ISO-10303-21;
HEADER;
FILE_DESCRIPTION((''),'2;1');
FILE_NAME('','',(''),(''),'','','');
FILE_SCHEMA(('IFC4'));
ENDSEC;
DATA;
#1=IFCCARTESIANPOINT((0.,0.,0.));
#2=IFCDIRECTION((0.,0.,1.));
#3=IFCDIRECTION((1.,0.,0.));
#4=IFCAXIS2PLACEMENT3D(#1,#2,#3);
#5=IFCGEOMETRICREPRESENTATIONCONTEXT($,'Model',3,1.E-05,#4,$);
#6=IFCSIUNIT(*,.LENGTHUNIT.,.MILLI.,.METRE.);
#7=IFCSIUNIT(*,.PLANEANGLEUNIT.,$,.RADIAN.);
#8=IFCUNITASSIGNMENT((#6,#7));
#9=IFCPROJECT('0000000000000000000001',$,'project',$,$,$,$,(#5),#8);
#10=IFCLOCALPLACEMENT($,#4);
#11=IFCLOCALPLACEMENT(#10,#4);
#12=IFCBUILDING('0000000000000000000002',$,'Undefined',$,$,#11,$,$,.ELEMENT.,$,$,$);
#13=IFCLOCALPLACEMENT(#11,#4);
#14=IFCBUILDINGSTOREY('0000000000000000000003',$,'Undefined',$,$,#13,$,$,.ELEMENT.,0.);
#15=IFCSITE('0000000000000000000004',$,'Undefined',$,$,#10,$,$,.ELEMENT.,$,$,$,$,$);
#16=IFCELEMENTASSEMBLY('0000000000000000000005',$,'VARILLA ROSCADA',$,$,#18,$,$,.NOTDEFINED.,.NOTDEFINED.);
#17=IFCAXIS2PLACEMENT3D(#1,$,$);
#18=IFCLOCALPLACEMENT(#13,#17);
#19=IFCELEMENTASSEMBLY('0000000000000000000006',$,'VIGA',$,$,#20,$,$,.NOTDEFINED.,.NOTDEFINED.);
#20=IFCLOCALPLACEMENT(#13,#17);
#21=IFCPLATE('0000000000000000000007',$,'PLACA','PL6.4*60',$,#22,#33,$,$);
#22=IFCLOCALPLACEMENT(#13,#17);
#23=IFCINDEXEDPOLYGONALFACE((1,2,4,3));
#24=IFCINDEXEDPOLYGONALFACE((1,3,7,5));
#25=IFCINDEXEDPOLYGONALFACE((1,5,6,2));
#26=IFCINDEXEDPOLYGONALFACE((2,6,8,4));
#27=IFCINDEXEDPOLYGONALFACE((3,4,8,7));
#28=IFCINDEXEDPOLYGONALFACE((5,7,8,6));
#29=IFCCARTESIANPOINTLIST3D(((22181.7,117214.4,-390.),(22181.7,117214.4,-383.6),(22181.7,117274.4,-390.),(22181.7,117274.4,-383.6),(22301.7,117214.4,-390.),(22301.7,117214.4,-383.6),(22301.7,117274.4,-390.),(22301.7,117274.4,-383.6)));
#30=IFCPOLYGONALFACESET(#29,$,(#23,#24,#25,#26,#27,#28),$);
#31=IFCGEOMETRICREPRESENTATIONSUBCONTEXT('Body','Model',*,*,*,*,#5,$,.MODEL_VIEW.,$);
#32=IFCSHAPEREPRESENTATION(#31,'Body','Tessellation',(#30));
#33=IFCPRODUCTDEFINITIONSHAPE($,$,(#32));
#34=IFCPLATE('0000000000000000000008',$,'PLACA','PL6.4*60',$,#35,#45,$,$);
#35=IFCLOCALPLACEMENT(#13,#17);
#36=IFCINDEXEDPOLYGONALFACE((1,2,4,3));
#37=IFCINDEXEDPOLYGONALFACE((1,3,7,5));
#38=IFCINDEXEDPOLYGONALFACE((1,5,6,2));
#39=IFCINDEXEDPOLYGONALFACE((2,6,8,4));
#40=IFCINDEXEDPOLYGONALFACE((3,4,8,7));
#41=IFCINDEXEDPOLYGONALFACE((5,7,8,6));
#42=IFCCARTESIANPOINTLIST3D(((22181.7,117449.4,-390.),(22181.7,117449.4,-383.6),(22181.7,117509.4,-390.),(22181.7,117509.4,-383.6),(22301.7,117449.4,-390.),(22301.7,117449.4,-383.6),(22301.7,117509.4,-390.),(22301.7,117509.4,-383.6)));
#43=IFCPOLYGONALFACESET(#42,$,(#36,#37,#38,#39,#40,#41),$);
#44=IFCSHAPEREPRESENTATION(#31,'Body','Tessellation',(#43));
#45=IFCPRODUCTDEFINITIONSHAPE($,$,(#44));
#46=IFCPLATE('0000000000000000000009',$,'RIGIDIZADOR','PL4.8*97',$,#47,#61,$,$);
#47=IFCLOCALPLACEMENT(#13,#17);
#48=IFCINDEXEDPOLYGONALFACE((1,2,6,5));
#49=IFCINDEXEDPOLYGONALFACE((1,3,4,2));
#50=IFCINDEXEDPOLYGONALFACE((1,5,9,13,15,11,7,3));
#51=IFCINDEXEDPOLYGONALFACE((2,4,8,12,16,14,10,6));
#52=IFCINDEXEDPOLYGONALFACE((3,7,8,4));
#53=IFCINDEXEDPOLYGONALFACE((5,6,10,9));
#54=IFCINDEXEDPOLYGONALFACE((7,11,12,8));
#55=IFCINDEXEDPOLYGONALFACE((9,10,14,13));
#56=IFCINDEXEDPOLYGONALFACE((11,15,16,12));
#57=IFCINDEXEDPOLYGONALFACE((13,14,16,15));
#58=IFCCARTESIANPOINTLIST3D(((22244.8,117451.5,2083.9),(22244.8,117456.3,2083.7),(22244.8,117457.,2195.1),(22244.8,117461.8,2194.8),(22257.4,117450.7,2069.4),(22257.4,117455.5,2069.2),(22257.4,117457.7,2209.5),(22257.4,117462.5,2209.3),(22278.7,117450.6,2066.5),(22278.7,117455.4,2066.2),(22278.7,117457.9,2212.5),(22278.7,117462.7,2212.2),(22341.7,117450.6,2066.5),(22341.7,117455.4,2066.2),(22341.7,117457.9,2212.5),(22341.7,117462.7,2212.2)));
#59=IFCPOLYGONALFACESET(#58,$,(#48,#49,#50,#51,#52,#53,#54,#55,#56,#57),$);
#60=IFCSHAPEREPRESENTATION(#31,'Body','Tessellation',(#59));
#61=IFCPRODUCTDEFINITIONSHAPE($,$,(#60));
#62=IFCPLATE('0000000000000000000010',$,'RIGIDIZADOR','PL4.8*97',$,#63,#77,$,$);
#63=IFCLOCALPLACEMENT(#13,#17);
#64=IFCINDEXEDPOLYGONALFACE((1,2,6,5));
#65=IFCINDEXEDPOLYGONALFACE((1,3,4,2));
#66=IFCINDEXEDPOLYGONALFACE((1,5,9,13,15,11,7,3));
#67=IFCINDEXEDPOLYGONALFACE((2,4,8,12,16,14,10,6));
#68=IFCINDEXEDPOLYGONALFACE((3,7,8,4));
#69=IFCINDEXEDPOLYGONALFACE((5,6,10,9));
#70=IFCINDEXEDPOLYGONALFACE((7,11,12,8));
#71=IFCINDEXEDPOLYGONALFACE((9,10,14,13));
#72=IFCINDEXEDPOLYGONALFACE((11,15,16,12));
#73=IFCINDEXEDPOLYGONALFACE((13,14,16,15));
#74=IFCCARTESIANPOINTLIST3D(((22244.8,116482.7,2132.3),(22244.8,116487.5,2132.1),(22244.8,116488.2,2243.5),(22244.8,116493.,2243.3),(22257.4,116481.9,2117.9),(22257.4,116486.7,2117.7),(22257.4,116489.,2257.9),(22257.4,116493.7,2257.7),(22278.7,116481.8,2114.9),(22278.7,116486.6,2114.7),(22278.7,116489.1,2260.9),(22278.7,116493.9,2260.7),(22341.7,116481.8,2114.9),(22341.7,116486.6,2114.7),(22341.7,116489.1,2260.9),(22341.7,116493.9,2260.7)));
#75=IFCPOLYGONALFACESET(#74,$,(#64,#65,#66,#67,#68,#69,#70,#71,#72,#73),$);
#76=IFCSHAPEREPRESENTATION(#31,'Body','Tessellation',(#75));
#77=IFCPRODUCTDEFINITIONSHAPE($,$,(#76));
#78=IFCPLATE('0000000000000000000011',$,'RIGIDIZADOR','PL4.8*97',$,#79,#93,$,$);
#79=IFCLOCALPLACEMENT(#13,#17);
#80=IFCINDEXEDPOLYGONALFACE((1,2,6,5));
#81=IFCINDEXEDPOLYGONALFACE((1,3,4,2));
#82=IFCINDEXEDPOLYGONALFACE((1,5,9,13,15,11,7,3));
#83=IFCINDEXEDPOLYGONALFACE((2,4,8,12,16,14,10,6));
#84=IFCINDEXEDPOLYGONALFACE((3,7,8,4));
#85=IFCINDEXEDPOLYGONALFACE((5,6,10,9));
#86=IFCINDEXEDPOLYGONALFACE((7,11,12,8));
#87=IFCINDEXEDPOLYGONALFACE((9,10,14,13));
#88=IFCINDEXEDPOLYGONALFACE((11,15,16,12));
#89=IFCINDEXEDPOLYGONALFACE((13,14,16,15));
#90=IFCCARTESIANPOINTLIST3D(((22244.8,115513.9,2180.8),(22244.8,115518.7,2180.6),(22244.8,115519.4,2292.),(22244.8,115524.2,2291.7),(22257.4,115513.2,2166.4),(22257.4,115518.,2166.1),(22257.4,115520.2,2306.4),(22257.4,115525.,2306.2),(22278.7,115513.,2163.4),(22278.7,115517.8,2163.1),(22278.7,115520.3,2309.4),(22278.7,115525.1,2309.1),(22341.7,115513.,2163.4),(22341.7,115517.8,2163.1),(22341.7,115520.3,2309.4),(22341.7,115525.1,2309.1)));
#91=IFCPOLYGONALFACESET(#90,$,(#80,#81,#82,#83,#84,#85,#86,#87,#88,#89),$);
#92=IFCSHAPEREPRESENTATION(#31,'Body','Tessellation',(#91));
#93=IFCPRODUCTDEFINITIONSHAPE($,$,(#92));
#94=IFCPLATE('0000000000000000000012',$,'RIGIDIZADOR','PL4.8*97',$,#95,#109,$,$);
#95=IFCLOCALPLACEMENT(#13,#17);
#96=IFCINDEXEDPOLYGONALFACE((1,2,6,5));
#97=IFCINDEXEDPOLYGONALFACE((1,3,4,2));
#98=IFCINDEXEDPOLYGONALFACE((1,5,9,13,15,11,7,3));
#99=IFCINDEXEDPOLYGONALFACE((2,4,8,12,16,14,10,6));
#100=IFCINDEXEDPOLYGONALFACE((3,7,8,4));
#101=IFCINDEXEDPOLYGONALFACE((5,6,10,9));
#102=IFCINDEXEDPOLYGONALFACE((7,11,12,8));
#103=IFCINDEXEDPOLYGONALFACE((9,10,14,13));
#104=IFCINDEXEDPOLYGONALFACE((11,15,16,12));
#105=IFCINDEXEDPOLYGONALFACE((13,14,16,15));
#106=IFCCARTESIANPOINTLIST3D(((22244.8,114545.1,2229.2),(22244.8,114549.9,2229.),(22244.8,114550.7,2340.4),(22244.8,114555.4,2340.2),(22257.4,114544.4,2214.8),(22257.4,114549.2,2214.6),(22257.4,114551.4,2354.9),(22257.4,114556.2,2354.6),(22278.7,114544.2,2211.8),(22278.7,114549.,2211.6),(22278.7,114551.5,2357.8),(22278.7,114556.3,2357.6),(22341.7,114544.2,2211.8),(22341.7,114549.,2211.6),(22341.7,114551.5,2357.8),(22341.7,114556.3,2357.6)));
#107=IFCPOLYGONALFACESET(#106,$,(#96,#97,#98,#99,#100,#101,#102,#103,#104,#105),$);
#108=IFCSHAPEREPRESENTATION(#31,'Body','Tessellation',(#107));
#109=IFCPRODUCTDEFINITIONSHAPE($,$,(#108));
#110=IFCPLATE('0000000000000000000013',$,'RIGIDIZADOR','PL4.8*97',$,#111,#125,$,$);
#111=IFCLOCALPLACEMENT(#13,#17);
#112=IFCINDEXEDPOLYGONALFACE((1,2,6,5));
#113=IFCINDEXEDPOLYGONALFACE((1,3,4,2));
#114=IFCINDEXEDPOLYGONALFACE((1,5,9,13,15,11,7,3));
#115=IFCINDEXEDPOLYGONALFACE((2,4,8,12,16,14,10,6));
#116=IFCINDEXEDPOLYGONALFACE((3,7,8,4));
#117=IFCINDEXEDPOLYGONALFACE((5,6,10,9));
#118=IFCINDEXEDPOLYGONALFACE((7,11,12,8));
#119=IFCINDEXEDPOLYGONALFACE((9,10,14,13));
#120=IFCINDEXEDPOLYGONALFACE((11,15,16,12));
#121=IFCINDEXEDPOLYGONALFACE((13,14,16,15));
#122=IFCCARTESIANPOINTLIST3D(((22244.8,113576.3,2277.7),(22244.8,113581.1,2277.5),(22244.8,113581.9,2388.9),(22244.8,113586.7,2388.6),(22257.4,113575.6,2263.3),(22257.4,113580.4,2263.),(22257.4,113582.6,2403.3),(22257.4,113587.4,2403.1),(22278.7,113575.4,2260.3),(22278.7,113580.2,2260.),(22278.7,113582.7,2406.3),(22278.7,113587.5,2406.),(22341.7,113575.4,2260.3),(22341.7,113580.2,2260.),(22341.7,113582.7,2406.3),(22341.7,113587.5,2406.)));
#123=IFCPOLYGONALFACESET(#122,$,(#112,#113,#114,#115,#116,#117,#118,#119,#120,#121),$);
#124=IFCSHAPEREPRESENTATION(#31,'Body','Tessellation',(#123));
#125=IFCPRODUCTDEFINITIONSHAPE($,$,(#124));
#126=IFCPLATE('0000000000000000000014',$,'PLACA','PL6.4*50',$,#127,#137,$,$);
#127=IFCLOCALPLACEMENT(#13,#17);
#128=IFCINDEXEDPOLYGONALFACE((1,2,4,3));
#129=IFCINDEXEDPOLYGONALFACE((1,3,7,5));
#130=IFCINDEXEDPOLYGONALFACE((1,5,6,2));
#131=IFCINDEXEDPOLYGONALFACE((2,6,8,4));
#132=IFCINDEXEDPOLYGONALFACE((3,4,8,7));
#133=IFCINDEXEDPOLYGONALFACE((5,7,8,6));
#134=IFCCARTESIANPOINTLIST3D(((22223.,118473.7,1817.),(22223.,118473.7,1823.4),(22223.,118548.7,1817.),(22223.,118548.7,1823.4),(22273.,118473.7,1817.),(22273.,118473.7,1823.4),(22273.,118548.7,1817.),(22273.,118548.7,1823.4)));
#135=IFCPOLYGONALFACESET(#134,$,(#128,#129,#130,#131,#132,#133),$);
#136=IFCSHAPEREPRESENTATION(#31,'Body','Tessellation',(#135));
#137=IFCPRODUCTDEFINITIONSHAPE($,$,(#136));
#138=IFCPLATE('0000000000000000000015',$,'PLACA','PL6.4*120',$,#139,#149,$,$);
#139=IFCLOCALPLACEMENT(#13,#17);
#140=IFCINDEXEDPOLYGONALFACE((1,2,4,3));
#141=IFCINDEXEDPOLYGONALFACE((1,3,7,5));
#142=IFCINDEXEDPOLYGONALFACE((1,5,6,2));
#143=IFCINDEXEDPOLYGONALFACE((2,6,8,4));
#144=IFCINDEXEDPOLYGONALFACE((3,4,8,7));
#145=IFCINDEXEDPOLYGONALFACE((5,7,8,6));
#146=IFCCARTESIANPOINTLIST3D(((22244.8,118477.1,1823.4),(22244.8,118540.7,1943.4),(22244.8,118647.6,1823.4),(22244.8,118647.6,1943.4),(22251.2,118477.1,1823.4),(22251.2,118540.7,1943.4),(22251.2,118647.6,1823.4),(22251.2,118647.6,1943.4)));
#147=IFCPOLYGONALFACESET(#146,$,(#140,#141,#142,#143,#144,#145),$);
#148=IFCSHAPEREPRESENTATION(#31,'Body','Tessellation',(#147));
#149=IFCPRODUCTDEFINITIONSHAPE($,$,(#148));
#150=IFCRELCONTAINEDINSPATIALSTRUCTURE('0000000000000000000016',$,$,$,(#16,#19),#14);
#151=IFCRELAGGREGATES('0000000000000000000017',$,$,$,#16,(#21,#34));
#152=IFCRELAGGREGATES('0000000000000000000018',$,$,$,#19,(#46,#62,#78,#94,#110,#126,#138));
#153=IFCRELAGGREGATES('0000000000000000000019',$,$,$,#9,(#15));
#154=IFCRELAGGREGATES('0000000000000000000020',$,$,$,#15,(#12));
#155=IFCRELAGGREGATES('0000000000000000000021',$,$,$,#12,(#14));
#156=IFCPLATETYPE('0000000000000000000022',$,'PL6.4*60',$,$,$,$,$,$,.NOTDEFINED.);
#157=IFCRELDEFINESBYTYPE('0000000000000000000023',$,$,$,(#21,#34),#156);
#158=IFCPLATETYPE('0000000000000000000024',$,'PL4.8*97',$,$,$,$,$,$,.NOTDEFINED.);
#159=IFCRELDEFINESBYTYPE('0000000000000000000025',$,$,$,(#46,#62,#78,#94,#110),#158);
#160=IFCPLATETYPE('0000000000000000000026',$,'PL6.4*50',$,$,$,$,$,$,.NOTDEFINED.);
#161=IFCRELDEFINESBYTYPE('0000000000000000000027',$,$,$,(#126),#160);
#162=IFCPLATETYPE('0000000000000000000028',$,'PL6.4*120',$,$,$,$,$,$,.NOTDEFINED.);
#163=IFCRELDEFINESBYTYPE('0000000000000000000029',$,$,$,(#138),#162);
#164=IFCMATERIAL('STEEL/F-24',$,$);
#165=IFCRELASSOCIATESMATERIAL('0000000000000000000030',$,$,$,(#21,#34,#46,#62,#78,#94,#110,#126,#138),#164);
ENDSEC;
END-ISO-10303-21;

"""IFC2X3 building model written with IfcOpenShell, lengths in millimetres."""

from ifc_helpers import new_model, si_unit, frame, origin_with_axes, place, context, subcontext, project, spatial, polyline, outline, extrude, material, type_object, element, aggregate, save


model = new_model("IFC2X3")

# Units and contexts
model_context = context("Model", 3, precision=1e-05, world=origin_with_axes())
body_context = subcontext(model_context, "Body", "Model", "MODEL_VIEW")
ifc_project = project(units=[si_unit("LENGTHUNIT", "METRE", prefix="MILLI"), si_unit("PLANEANGLEUNIT", "RADIAN")], contexts=[model_context])

# Site, building, storey
site_placement = place(None, origin_with_axes())
site = spatial("IfcSite", under=ifc_project, at=site_placement, Name="Undefined", CompositionType="ELEMENT")
building_placement = place(site_placement, origin_with_axes())
building = spatial("IfcBuilding", under=site, at=building_placement, Name="Undefined", CompositionType="ELEMENT")
storey_placement = place(building_placement, origin_with_axes())
storey = spatial("IfcBuildingStorey", under=building, at=storey_placement, Name="Undefined", CompositionType="ELEMENT", Elevation=0.0)

# Element assembly
assembly_1_placement = place(storey_placement, origin_with_axes())
assembly_1 = element("IfcElementAssembly", 1, at=assembly_1_placement, inside=storey, Name="VARILLA ROSCADA", AssemblyPlace="NOTDEFINED", PredefinedType="NOTDEFINED")

# Element assembly
assembly_2_placement = place(storey_placement, origin_with_axes())
assembly_2 = element("IfcElementAssembly", 2, at=assembly_2_placement, inside=storey, Name="VIGA", AssemblyPlace="NOTDEFINED", PredefinedType="NOTDEFINED")
ifc_material_1 = material(Name="STEEL/F-24")

# Plates
plate_type_1 = type_object("IfcPlateType", Name="PL6.4*60", PredefinedType="NOTDEFINED")
plate_1_placement = place(assembly_1_placement, frame((22181.7, 117214.4, -386.8), z_axis=(0.0, 0.0, 1.0), x_axis=(1.0, 0.0, 0.0)))
plate_1 = element("IfcPlate", 3, at=plate_1_placement, type_object=plate_type_1, material=ifc_material_1, Name="PLACA", Description="PL6.4*60", context=body_context, shape_type="SweptSolid", body=[
    extrude(outline(polyline([(0.0, 0.0), (120.0, 0.0), (120.0, 60.0), (0.0, 60.0), (0.0, 0.0)])), frame((0.0, 0.0, -3.2), z_axis=(0.0, 0.0, 1.0), x_axis=(1.0, 0.0, 0.0)), (0.0, 0.0, 1.0), 6.4),
])
plate_2_placement = place(assembly_1_placement, frame((22181.7, 117449.4, -386.8), z_axis=(0.0, 0.0, 1.0), x_axis=(1.0, 0.0, 0.0)))
plate_2 = element("IfcPlate", 4, at=plate_2_placement, type_object=plate_type_1, material=ifc_material_1, Name="PLACA", Description="PL6.4*60", context=body_context, shape_type="SweptSolid", body=[
    extrude(outline(polyline([(0.0, 0.0), (120.0, 0.0), (120.0, 60.0), (0.0, 60.0), (0.0, 0.0)])), frame((0.0, 0.0, -3.2), z_axis=(0.0, 0.0, 1.0), x_axis=(1.0, 0.0, 0.0)), (0.0, 0.0, 1.0), 6.4),
])
plate_type_2 = type_object("IfcPlateType", Name="PL4.8*97", PredefinedType="NOTDEFINED")
plate_3_placement = place(assembly_2_placement, frame((22341.7, 117460.3, 2212.4), z_axis=(0.0, -0.998752, 0.04995), x_axis=(-1.0, 0.0, 0.0)))
plate_3 = element("IfcPlate", 5, at=plate_3_placement, type_object=plate_type_2, material=ifc_material_1, Name="RIGIDIZADOR", Description="PL4.8*97", context=body_context, shape_type="SweptSolid", body=[
    extrude(outline(polyline([(0.0, 0.0), (63.0, 0.0), (84.3, 3.0), (96.8, 17.4), (96.8, 128.7), (84.3, 143.2), (63.0, 146.2), (0.0, 146.2), (0.0, 0.0)])), frame((0.0, 0.0, -2.4), z_axis=(0.0, 0.0, 1.0), x_axis=(1.0, 0.0, 0.0)), (0.0, 0.0, 1.0), 4.8),
])
plate_4_placement = place(assembly_2_placement, frame((22341.7, 116491.5, 2260.8), z_axis=(0.0, -0.998752, 0.04995), x_axis=(-1.0, 0.0, 0.0)))
plate_4 = element("IfcPlate", 6, at=plate_4_placement, type_object=plate_type_2, material=ifc_material_1, Name="RIGIDIZADOR", Description="PL4.8*97", context=body_context, shape_type="SweptSolid", body=[
    extrude(outline(polyline([(0.0, 0.0), (63.0, 0.0), (84.3, 3.0), (96.8, 17.4), (96.8, 128.7), (84.3, 143.2), (63.0, 146.2), (0.0, 146.2), (0.0, 0.0)])), frame((0.0, 0.0, -2.4), z_axis=(0.0, 0.0, 1.0), x_axis=(1.0, 0.0, 0.0)), (0.0, 0.0, 1.0), 4.8),
])
plate_5_placement = place(assembly_2_placement, frame((22341.7, 115522.7, 2309.3), z_axis=(0.0, -0.998752, 0.04995), x_axis=(-1.0, 0.0, 0.0)))
plate_5 = element("IfcPlate", 7, at=plate_5_placement, type_object=plate_type_2, material=ifc_material_1, Name="RIGIDIZADOR", Description="PL4.8*97", context=body_context, shape_type="SweptSolid", body=[
    extrude(outline(polyline([(0.0, 0.0), (63.0, 0.0), (84.3, 3.0), (96.8, 17.4), (96.8, 128.7), (84.3, 143.2), (63.0, 146.2), (0.0, 146.2), (0.0, 0.0)])), frame((0.0, 0.0, -2.4), z_axis=(0.0, 0.0, 1.0), x_axis=(1.0, 0.0, 0.0)), (0.0, 0.0, 1.0), 4.8),
])
plate_6_placement = place(assembly_2_placement, frame((22341.7, 114553.9, 2357.7), z_axis=(0.0, -0.998752, 0.04995), x_axis=(-1.0, 0.0, 0.0)))
plate_6 = element("IfcPlate", 8, at=plate_6_placement, type_object=plate_type_2, material=ifc_material_1, Name="RIGIDIZADOR", Description="PL4.8*97", context=body_context, shape_type="SweptSolid", body=[
    extrude(outline(polyline([(0.0, 0.0), (63.0, 0.0), (84.3, 3.0), (96.8, 17.4), (96.8, 128.7), (84.3, 143.2), (63.0, 146.2), (0.0, 146.2), (0.0, 0.0)])), frame((0.0, 0.0, -2.4), z_axis=(0.0, 0.0, 1.0), x_axis=(1.0, 0.0, 0.0)), (0.0, 0.0, 1.0), 4.8),
])
plate_7_placement = place(assembly_2_placement, frame((22341.7, 113585.1, 2406.2), z_axis=(0.0, -0.998752, 0.04995), x_axis=(-1.0, 0.0, 0.0)))
plate_7 = element("IfcPlate", 9, at=plate_7_placement, type_object=plate_type_2, material=ifc_material_1, Name="RIGIDIZADOR", Description="PL4.8*97", context=body_context, shape_type="SweptSolid", body=[
    extrude(outline(polyline([(0.0, 0.0), (63.0, 0.0), (84.3, 3.0), (96.8, 17.4), (96.8, 128.7), (84.3, 143.2), (63.0, 146.2), (0.0, 146.2), (0.0, 0.0)])), frame((0.0, 0.0, -2.4), z_axis=(0.0, 0.0, 1.0), x_axis=(1.0, 0.0, 0.0)), (0.0, 0.0, 1.0), 4.8),
])
plate_type_3 = type_object("IfcPlateType", Name="PL6.4*50", PredefinedType="NOTDEFINED")
plate_8_placement = place(assembly_2_placement, frame((22223.0, 118473.7, 1820.2), z_axis=(0.0, 0.0, -1.0), x_axis=(0.0, 1.0, 0.0)))
plate_8 = element("IfcPlate", 10, at=plate_8_placement, type_object=plate_type_3, material=ifc_material_1, Name="PLACA", Description="PL6.4*50", context=body_context, shape_type="SweptSolid", body=[
    extrude(outline(polyline([(0.0, 0.0), (75.0, 0.0), (75.0, 50.0), (0.0, 50.0), (0.0, 0.0)])), frame((0.0, 0.0, -3.2), z_axis=(0.0, 0.0, 1.0), x_axis=(1.0, 0.0, 0.0)), (0.0, 0.0, 1.0), 6.4),
])
plate_type_4 = type_object("IfcPlateType", Name="PL6.4*120", PredefinedType="NOTDEFINED")
plate_9_placement = place(assembly_2_placement, frame((22248.0, 118540.7, 1943.4), z_axis=(-1.0, 0.0, 0.0), x_axis=(0.0, 1.0, 0.0)))
plate_9 = element("IfcPlate", 11, at=plate_9_placement, type_object=plate_type_4, material=ifc_material_1, Name="PLACA", Description="PL6.4*120", context=body_context, shape_type="SweptSolid", body=[
    extrude(outline(polyline([(0.0, 0.0), (106.8, 0.0), (106.8, 120.0), (-63.7, 120.0), (0.0, 0.0)])), frame((0.0, 0.0, -3.2), z_axis=(0.0, 0.0, 1.0), x_axis=(1.0, 0.0, 0.0)), (0.0, 0.0, 1.0), 6.4),
])

aggregate(assembly_1, [plate_1, plate_2])

aggregate(assembly_2, [plate_3, plate_4, plate_5, plate_6, plate_7, plate_8, plate_9])

save(model, "model.ifc")
